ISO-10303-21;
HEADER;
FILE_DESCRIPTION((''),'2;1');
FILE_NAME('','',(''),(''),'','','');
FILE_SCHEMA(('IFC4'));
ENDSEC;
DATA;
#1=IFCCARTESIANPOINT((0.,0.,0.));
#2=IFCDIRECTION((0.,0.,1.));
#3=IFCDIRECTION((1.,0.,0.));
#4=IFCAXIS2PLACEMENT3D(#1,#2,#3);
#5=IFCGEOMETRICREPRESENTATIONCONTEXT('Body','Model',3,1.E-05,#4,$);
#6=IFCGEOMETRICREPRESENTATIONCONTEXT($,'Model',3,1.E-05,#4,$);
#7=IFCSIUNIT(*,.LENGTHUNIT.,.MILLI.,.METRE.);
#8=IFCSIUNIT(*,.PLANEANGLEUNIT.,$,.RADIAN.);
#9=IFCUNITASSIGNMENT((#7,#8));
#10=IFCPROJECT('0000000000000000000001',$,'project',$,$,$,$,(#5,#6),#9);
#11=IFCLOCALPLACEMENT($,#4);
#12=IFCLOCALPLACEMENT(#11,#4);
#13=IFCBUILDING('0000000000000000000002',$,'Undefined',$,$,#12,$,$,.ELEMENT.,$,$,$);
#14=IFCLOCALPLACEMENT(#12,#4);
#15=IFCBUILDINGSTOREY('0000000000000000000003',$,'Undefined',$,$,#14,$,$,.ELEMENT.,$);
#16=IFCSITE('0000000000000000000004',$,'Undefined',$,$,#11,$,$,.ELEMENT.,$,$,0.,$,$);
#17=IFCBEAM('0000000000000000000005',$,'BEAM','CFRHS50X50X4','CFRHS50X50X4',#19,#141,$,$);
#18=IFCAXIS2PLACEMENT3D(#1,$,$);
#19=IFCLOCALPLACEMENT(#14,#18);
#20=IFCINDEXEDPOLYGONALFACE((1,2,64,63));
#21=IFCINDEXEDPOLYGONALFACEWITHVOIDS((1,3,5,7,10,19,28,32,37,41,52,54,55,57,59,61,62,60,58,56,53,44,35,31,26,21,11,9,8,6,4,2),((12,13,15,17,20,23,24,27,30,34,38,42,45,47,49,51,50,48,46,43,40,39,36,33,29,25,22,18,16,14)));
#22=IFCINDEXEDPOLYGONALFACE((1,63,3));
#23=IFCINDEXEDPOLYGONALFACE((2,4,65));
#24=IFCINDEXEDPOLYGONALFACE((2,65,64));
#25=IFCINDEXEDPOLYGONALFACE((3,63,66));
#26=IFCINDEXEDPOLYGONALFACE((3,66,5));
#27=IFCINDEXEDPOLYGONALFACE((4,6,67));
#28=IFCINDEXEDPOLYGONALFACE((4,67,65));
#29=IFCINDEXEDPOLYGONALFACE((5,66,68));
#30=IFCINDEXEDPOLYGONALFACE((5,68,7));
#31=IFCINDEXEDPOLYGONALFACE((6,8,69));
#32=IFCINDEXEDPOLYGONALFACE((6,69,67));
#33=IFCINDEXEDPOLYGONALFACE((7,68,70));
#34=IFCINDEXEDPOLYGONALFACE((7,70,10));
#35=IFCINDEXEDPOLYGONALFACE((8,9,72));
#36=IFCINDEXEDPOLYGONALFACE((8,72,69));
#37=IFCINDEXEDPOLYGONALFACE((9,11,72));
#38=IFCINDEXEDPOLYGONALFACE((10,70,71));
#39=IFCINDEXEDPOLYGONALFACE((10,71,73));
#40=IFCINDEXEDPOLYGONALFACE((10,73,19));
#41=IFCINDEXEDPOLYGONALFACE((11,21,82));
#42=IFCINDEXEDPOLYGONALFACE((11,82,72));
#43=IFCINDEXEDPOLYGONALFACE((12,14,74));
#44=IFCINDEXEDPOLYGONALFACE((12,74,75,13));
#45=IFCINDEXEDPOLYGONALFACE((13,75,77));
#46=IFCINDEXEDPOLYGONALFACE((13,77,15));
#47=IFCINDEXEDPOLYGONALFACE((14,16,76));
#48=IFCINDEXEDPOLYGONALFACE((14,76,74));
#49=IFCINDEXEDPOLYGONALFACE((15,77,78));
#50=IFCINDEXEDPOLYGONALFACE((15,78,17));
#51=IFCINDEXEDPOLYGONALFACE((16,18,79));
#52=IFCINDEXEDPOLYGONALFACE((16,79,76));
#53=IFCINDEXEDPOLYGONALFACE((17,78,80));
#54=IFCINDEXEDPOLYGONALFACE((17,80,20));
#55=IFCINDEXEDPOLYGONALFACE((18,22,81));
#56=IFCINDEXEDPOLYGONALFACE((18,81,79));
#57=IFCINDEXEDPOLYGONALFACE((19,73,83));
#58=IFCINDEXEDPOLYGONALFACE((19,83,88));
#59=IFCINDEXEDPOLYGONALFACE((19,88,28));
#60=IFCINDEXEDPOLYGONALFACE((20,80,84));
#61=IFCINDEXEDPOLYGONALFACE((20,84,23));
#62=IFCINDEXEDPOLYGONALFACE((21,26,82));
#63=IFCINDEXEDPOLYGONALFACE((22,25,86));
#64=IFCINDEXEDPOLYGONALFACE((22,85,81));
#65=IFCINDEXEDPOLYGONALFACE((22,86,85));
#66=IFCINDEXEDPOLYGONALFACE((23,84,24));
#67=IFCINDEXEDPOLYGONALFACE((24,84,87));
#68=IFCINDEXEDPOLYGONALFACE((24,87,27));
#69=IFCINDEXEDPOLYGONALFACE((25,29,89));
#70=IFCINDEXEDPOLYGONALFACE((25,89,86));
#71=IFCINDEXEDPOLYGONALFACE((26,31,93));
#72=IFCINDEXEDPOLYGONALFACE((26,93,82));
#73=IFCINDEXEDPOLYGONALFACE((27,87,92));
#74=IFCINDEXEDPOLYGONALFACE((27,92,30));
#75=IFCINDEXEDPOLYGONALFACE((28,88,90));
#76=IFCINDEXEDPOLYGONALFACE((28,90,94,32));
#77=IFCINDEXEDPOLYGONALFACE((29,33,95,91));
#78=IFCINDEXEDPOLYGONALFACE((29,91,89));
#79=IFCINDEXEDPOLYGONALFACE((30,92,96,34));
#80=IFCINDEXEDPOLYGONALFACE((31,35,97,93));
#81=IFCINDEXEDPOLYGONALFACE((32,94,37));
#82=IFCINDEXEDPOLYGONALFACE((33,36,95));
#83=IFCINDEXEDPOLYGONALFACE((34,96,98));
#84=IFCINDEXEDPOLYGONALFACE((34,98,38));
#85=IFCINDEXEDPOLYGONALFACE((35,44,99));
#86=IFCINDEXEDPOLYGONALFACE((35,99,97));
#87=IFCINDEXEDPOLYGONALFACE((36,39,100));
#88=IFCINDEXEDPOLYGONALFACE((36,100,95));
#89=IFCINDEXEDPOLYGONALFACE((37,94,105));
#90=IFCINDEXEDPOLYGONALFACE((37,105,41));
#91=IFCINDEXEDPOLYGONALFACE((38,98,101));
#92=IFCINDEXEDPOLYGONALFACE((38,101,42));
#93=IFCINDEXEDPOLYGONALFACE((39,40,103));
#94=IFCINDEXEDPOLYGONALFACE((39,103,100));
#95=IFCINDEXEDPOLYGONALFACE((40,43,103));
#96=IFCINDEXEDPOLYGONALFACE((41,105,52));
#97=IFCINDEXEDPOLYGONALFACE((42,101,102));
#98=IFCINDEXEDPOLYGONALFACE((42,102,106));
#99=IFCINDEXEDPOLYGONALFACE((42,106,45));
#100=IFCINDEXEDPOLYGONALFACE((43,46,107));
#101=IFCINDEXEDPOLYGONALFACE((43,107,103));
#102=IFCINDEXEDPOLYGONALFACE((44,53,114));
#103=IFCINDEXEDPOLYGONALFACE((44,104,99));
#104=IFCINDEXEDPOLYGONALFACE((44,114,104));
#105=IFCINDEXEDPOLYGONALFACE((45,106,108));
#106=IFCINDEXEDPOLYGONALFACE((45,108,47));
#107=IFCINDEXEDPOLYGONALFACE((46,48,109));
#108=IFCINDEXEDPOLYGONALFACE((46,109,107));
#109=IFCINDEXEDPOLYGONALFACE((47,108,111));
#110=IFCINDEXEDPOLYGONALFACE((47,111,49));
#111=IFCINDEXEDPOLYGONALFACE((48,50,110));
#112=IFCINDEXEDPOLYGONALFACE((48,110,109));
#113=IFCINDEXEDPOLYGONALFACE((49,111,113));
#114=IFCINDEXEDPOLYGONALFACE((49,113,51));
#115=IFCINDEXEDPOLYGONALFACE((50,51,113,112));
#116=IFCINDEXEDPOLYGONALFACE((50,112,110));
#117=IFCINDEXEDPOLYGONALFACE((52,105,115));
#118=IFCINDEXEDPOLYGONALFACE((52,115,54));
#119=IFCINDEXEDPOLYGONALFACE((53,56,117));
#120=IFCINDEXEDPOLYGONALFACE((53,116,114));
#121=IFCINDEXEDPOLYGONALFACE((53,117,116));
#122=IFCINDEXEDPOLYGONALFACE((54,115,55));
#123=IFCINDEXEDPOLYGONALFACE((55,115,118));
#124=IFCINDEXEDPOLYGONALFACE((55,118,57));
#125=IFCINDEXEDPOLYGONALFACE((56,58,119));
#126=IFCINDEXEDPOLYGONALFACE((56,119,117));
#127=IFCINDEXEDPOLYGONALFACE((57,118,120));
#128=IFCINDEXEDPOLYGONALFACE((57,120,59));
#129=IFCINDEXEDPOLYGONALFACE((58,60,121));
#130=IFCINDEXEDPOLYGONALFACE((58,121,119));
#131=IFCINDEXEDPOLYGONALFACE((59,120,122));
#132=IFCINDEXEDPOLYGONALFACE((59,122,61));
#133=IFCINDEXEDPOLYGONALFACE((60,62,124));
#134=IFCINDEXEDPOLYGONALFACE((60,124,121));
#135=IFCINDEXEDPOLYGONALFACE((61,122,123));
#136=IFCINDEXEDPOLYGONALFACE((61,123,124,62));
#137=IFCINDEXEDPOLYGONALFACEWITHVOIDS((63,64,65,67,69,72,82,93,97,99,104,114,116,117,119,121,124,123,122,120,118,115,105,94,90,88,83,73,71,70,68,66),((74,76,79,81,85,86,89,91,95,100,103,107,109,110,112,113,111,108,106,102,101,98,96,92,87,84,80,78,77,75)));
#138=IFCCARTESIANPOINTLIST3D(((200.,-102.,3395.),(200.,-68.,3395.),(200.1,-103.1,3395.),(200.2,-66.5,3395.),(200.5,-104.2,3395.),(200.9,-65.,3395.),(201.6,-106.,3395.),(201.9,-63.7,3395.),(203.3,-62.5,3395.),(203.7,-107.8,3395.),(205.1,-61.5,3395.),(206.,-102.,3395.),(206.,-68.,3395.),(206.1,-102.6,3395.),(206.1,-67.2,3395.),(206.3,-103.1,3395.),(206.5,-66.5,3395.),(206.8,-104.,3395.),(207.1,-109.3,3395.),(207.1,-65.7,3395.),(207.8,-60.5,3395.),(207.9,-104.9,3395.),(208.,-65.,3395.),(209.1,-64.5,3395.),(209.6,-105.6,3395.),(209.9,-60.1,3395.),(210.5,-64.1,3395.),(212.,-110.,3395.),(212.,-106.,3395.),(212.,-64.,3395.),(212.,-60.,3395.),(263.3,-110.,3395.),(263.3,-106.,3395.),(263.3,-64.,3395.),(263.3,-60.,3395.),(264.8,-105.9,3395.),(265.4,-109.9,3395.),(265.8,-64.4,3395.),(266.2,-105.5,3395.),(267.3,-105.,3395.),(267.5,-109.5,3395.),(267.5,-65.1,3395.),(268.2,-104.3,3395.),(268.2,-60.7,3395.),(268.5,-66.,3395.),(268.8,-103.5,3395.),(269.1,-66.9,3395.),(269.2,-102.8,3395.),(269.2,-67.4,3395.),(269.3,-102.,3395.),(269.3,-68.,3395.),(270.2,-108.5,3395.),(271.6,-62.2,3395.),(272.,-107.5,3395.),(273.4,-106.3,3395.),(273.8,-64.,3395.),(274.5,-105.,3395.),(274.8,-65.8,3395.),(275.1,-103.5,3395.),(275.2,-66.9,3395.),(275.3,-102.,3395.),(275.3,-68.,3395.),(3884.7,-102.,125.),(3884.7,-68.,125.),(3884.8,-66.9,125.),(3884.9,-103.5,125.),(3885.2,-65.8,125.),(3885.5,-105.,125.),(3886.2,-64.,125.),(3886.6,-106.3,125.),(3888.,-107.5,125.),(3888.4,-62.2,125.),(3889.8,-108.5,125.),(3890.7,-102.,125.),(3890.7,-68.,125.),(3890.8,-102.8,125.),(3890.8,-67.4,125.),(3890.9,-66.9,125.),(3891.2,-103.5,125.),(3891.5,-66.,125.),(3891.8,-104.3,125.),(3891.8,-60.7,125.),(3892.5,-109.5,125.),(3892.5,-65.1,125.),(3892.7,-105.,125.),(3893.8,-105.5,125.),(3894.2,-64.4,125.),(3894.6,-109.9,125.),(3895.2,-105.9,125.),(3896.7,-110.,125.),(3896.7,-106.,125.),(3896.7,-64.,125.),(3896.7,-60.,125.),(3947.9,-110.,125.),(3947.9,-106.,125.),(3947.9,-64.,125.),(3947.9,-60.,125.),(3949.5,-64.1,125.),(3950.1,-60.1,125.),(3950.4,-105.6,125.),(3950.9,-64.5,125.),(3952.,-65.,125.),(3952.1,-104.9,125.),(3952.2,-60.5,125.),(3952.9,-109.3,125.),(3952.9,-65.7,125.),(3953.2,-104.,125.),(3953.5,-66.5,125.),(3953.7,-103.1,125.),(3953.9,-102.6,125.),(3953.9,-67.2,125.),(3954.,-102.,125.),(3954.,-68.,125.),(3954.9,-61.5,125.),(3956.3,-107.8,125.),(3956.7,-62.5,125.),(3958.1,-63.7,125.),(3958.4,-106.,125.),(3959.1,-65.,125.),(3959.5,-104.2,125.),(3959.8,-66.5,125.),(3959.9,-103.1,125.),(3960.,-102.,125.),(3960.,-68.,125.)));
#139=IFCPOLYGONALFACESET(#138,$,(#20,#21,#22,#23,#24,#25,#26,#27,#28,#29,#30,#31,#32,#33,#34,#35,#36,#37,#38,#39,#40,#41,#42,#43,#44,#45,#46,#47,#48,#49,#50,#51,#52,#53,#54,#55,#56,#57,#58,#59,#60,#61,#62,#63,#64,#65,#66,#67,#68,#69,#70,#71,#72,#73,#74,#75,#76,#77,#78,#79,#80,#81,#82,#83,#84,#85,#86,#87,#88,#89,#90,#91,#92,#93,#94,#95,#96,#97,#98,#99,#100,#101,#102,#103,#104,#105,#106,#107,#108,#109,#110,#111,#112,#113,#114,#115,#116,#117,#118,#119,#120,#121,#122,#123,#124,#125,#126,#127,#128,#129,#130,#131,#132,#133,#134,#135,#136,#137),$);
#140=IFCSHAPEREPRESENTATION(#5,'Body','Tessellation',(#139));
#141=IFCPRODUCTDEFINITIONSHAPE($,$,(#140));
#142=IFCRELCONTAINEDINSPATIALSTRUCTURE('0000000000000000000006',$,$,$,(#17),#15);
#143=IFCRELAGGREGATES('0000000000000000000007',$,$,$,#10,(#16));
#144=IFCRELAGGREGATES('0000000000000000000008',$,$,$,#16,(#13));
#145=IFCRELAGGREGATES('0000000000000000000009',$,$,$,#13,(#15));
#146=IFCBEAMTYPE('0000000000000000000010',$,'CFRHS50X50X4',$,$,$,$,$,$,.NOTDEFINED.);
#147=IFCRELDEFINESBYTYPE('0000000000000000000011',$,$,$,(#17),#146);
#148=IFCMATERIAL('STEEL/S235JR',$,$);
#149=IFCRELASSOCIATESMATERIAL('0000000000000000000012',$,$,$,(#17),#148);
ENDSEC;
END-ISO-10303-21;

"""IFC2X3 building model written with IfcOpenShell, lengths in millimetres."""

from ifc_helpers import new_model, si_unit, frame, origin_with_axes, origin_2d_with_axis, place, context, project, spatial, hollow_rectangle, extrude, clip, halfspace, material, type_object, element, save


model = new_model("IFC2X3")

# Units and contexts
model_context_1 = context("Model", 3, precision=1e-05, world=origin_with_axes(), identifier="Body")
model_context_2 = context("Model", 3, precision=1e-05, world=origin_with_axes())
ifc_project = project(units=[si_unit("LENGTHUNIT", "METRE", prefix="MILLI"), si_unit("PLANEANGLEUNIT", "RADIAN")], contexts=[model_context_1, model_context_2])

# Site, building, storey
site_placement = place(None, origin_with_axes())
site = spatial("IfcSite", under=ifc_project, at=site_placement, Name="Undefined", CompositionType="ELEMENT", RefElevation=0.0)
building_placement = place(site_placement, origin_with_axes())
building = spatial("IfcBuilding", under=site, at=building_placement, Name="Undefined", CompositionType="ELEMENT")
storey_placement = place(building_placement, origin_with_axes())
storey = spatial("IfcBuildingStorey", under=building, at=storey_placement, Name="Undefined", CompositionType="ELEMENT")

# Shared definitions
ifc_material = material(Name="STEEL/S235JR")

# Beam
beam_type_1 = type_object("IfcBeamType", Name="CFRHS50X50X4", PredefinedType="NOTDEFINED")
beam_1_placement = place(storey_placement, frame((216.6, -85.0, 3413.7), z_axis=(0.0, -1.0, 0.0), x_axis=(0.74794, 0.0, -0.663766)))
element("IfcBeam", 1, at=beam_1_placement, inside=storey, type_object=beam_type_1, material=ifc_material, Name="BEAM", Description="CFRHS50X50X4", ObjectType="CFRHS50X50X4", context=model_context_1, shape_type="Clipping", body=[
    clip(clip(extrude(hollow_rectangle(XDim=50.0, YDim=50.0, WallThickness=4.0, InnerFilletRadius=4.0, OuterFilletRadius=8.0, at=origin_2d_with_axis()), frame((5011.5, 0.0, 0.0), z_axis=(-1.0, 0.0, 0.0), x_axis=(0.0, -1.0, 0.0)), (0.0, 0.0, 1.0), 5040.2), halfspace(frame((4917.5, -32.9, -85.0), z_axis=(-0.663766, 0.74794, 0.0), x_axis=(0.74794, 0.663766, 0.0)), True)), halfspace(frame((62.5, 30.4, -85.0), z_axis=(0.663766, -0.74794, 0.0), x_axis=(-0.74794, -0.663766, 0.0)), True)),
])

save(model, "model.ifc")
